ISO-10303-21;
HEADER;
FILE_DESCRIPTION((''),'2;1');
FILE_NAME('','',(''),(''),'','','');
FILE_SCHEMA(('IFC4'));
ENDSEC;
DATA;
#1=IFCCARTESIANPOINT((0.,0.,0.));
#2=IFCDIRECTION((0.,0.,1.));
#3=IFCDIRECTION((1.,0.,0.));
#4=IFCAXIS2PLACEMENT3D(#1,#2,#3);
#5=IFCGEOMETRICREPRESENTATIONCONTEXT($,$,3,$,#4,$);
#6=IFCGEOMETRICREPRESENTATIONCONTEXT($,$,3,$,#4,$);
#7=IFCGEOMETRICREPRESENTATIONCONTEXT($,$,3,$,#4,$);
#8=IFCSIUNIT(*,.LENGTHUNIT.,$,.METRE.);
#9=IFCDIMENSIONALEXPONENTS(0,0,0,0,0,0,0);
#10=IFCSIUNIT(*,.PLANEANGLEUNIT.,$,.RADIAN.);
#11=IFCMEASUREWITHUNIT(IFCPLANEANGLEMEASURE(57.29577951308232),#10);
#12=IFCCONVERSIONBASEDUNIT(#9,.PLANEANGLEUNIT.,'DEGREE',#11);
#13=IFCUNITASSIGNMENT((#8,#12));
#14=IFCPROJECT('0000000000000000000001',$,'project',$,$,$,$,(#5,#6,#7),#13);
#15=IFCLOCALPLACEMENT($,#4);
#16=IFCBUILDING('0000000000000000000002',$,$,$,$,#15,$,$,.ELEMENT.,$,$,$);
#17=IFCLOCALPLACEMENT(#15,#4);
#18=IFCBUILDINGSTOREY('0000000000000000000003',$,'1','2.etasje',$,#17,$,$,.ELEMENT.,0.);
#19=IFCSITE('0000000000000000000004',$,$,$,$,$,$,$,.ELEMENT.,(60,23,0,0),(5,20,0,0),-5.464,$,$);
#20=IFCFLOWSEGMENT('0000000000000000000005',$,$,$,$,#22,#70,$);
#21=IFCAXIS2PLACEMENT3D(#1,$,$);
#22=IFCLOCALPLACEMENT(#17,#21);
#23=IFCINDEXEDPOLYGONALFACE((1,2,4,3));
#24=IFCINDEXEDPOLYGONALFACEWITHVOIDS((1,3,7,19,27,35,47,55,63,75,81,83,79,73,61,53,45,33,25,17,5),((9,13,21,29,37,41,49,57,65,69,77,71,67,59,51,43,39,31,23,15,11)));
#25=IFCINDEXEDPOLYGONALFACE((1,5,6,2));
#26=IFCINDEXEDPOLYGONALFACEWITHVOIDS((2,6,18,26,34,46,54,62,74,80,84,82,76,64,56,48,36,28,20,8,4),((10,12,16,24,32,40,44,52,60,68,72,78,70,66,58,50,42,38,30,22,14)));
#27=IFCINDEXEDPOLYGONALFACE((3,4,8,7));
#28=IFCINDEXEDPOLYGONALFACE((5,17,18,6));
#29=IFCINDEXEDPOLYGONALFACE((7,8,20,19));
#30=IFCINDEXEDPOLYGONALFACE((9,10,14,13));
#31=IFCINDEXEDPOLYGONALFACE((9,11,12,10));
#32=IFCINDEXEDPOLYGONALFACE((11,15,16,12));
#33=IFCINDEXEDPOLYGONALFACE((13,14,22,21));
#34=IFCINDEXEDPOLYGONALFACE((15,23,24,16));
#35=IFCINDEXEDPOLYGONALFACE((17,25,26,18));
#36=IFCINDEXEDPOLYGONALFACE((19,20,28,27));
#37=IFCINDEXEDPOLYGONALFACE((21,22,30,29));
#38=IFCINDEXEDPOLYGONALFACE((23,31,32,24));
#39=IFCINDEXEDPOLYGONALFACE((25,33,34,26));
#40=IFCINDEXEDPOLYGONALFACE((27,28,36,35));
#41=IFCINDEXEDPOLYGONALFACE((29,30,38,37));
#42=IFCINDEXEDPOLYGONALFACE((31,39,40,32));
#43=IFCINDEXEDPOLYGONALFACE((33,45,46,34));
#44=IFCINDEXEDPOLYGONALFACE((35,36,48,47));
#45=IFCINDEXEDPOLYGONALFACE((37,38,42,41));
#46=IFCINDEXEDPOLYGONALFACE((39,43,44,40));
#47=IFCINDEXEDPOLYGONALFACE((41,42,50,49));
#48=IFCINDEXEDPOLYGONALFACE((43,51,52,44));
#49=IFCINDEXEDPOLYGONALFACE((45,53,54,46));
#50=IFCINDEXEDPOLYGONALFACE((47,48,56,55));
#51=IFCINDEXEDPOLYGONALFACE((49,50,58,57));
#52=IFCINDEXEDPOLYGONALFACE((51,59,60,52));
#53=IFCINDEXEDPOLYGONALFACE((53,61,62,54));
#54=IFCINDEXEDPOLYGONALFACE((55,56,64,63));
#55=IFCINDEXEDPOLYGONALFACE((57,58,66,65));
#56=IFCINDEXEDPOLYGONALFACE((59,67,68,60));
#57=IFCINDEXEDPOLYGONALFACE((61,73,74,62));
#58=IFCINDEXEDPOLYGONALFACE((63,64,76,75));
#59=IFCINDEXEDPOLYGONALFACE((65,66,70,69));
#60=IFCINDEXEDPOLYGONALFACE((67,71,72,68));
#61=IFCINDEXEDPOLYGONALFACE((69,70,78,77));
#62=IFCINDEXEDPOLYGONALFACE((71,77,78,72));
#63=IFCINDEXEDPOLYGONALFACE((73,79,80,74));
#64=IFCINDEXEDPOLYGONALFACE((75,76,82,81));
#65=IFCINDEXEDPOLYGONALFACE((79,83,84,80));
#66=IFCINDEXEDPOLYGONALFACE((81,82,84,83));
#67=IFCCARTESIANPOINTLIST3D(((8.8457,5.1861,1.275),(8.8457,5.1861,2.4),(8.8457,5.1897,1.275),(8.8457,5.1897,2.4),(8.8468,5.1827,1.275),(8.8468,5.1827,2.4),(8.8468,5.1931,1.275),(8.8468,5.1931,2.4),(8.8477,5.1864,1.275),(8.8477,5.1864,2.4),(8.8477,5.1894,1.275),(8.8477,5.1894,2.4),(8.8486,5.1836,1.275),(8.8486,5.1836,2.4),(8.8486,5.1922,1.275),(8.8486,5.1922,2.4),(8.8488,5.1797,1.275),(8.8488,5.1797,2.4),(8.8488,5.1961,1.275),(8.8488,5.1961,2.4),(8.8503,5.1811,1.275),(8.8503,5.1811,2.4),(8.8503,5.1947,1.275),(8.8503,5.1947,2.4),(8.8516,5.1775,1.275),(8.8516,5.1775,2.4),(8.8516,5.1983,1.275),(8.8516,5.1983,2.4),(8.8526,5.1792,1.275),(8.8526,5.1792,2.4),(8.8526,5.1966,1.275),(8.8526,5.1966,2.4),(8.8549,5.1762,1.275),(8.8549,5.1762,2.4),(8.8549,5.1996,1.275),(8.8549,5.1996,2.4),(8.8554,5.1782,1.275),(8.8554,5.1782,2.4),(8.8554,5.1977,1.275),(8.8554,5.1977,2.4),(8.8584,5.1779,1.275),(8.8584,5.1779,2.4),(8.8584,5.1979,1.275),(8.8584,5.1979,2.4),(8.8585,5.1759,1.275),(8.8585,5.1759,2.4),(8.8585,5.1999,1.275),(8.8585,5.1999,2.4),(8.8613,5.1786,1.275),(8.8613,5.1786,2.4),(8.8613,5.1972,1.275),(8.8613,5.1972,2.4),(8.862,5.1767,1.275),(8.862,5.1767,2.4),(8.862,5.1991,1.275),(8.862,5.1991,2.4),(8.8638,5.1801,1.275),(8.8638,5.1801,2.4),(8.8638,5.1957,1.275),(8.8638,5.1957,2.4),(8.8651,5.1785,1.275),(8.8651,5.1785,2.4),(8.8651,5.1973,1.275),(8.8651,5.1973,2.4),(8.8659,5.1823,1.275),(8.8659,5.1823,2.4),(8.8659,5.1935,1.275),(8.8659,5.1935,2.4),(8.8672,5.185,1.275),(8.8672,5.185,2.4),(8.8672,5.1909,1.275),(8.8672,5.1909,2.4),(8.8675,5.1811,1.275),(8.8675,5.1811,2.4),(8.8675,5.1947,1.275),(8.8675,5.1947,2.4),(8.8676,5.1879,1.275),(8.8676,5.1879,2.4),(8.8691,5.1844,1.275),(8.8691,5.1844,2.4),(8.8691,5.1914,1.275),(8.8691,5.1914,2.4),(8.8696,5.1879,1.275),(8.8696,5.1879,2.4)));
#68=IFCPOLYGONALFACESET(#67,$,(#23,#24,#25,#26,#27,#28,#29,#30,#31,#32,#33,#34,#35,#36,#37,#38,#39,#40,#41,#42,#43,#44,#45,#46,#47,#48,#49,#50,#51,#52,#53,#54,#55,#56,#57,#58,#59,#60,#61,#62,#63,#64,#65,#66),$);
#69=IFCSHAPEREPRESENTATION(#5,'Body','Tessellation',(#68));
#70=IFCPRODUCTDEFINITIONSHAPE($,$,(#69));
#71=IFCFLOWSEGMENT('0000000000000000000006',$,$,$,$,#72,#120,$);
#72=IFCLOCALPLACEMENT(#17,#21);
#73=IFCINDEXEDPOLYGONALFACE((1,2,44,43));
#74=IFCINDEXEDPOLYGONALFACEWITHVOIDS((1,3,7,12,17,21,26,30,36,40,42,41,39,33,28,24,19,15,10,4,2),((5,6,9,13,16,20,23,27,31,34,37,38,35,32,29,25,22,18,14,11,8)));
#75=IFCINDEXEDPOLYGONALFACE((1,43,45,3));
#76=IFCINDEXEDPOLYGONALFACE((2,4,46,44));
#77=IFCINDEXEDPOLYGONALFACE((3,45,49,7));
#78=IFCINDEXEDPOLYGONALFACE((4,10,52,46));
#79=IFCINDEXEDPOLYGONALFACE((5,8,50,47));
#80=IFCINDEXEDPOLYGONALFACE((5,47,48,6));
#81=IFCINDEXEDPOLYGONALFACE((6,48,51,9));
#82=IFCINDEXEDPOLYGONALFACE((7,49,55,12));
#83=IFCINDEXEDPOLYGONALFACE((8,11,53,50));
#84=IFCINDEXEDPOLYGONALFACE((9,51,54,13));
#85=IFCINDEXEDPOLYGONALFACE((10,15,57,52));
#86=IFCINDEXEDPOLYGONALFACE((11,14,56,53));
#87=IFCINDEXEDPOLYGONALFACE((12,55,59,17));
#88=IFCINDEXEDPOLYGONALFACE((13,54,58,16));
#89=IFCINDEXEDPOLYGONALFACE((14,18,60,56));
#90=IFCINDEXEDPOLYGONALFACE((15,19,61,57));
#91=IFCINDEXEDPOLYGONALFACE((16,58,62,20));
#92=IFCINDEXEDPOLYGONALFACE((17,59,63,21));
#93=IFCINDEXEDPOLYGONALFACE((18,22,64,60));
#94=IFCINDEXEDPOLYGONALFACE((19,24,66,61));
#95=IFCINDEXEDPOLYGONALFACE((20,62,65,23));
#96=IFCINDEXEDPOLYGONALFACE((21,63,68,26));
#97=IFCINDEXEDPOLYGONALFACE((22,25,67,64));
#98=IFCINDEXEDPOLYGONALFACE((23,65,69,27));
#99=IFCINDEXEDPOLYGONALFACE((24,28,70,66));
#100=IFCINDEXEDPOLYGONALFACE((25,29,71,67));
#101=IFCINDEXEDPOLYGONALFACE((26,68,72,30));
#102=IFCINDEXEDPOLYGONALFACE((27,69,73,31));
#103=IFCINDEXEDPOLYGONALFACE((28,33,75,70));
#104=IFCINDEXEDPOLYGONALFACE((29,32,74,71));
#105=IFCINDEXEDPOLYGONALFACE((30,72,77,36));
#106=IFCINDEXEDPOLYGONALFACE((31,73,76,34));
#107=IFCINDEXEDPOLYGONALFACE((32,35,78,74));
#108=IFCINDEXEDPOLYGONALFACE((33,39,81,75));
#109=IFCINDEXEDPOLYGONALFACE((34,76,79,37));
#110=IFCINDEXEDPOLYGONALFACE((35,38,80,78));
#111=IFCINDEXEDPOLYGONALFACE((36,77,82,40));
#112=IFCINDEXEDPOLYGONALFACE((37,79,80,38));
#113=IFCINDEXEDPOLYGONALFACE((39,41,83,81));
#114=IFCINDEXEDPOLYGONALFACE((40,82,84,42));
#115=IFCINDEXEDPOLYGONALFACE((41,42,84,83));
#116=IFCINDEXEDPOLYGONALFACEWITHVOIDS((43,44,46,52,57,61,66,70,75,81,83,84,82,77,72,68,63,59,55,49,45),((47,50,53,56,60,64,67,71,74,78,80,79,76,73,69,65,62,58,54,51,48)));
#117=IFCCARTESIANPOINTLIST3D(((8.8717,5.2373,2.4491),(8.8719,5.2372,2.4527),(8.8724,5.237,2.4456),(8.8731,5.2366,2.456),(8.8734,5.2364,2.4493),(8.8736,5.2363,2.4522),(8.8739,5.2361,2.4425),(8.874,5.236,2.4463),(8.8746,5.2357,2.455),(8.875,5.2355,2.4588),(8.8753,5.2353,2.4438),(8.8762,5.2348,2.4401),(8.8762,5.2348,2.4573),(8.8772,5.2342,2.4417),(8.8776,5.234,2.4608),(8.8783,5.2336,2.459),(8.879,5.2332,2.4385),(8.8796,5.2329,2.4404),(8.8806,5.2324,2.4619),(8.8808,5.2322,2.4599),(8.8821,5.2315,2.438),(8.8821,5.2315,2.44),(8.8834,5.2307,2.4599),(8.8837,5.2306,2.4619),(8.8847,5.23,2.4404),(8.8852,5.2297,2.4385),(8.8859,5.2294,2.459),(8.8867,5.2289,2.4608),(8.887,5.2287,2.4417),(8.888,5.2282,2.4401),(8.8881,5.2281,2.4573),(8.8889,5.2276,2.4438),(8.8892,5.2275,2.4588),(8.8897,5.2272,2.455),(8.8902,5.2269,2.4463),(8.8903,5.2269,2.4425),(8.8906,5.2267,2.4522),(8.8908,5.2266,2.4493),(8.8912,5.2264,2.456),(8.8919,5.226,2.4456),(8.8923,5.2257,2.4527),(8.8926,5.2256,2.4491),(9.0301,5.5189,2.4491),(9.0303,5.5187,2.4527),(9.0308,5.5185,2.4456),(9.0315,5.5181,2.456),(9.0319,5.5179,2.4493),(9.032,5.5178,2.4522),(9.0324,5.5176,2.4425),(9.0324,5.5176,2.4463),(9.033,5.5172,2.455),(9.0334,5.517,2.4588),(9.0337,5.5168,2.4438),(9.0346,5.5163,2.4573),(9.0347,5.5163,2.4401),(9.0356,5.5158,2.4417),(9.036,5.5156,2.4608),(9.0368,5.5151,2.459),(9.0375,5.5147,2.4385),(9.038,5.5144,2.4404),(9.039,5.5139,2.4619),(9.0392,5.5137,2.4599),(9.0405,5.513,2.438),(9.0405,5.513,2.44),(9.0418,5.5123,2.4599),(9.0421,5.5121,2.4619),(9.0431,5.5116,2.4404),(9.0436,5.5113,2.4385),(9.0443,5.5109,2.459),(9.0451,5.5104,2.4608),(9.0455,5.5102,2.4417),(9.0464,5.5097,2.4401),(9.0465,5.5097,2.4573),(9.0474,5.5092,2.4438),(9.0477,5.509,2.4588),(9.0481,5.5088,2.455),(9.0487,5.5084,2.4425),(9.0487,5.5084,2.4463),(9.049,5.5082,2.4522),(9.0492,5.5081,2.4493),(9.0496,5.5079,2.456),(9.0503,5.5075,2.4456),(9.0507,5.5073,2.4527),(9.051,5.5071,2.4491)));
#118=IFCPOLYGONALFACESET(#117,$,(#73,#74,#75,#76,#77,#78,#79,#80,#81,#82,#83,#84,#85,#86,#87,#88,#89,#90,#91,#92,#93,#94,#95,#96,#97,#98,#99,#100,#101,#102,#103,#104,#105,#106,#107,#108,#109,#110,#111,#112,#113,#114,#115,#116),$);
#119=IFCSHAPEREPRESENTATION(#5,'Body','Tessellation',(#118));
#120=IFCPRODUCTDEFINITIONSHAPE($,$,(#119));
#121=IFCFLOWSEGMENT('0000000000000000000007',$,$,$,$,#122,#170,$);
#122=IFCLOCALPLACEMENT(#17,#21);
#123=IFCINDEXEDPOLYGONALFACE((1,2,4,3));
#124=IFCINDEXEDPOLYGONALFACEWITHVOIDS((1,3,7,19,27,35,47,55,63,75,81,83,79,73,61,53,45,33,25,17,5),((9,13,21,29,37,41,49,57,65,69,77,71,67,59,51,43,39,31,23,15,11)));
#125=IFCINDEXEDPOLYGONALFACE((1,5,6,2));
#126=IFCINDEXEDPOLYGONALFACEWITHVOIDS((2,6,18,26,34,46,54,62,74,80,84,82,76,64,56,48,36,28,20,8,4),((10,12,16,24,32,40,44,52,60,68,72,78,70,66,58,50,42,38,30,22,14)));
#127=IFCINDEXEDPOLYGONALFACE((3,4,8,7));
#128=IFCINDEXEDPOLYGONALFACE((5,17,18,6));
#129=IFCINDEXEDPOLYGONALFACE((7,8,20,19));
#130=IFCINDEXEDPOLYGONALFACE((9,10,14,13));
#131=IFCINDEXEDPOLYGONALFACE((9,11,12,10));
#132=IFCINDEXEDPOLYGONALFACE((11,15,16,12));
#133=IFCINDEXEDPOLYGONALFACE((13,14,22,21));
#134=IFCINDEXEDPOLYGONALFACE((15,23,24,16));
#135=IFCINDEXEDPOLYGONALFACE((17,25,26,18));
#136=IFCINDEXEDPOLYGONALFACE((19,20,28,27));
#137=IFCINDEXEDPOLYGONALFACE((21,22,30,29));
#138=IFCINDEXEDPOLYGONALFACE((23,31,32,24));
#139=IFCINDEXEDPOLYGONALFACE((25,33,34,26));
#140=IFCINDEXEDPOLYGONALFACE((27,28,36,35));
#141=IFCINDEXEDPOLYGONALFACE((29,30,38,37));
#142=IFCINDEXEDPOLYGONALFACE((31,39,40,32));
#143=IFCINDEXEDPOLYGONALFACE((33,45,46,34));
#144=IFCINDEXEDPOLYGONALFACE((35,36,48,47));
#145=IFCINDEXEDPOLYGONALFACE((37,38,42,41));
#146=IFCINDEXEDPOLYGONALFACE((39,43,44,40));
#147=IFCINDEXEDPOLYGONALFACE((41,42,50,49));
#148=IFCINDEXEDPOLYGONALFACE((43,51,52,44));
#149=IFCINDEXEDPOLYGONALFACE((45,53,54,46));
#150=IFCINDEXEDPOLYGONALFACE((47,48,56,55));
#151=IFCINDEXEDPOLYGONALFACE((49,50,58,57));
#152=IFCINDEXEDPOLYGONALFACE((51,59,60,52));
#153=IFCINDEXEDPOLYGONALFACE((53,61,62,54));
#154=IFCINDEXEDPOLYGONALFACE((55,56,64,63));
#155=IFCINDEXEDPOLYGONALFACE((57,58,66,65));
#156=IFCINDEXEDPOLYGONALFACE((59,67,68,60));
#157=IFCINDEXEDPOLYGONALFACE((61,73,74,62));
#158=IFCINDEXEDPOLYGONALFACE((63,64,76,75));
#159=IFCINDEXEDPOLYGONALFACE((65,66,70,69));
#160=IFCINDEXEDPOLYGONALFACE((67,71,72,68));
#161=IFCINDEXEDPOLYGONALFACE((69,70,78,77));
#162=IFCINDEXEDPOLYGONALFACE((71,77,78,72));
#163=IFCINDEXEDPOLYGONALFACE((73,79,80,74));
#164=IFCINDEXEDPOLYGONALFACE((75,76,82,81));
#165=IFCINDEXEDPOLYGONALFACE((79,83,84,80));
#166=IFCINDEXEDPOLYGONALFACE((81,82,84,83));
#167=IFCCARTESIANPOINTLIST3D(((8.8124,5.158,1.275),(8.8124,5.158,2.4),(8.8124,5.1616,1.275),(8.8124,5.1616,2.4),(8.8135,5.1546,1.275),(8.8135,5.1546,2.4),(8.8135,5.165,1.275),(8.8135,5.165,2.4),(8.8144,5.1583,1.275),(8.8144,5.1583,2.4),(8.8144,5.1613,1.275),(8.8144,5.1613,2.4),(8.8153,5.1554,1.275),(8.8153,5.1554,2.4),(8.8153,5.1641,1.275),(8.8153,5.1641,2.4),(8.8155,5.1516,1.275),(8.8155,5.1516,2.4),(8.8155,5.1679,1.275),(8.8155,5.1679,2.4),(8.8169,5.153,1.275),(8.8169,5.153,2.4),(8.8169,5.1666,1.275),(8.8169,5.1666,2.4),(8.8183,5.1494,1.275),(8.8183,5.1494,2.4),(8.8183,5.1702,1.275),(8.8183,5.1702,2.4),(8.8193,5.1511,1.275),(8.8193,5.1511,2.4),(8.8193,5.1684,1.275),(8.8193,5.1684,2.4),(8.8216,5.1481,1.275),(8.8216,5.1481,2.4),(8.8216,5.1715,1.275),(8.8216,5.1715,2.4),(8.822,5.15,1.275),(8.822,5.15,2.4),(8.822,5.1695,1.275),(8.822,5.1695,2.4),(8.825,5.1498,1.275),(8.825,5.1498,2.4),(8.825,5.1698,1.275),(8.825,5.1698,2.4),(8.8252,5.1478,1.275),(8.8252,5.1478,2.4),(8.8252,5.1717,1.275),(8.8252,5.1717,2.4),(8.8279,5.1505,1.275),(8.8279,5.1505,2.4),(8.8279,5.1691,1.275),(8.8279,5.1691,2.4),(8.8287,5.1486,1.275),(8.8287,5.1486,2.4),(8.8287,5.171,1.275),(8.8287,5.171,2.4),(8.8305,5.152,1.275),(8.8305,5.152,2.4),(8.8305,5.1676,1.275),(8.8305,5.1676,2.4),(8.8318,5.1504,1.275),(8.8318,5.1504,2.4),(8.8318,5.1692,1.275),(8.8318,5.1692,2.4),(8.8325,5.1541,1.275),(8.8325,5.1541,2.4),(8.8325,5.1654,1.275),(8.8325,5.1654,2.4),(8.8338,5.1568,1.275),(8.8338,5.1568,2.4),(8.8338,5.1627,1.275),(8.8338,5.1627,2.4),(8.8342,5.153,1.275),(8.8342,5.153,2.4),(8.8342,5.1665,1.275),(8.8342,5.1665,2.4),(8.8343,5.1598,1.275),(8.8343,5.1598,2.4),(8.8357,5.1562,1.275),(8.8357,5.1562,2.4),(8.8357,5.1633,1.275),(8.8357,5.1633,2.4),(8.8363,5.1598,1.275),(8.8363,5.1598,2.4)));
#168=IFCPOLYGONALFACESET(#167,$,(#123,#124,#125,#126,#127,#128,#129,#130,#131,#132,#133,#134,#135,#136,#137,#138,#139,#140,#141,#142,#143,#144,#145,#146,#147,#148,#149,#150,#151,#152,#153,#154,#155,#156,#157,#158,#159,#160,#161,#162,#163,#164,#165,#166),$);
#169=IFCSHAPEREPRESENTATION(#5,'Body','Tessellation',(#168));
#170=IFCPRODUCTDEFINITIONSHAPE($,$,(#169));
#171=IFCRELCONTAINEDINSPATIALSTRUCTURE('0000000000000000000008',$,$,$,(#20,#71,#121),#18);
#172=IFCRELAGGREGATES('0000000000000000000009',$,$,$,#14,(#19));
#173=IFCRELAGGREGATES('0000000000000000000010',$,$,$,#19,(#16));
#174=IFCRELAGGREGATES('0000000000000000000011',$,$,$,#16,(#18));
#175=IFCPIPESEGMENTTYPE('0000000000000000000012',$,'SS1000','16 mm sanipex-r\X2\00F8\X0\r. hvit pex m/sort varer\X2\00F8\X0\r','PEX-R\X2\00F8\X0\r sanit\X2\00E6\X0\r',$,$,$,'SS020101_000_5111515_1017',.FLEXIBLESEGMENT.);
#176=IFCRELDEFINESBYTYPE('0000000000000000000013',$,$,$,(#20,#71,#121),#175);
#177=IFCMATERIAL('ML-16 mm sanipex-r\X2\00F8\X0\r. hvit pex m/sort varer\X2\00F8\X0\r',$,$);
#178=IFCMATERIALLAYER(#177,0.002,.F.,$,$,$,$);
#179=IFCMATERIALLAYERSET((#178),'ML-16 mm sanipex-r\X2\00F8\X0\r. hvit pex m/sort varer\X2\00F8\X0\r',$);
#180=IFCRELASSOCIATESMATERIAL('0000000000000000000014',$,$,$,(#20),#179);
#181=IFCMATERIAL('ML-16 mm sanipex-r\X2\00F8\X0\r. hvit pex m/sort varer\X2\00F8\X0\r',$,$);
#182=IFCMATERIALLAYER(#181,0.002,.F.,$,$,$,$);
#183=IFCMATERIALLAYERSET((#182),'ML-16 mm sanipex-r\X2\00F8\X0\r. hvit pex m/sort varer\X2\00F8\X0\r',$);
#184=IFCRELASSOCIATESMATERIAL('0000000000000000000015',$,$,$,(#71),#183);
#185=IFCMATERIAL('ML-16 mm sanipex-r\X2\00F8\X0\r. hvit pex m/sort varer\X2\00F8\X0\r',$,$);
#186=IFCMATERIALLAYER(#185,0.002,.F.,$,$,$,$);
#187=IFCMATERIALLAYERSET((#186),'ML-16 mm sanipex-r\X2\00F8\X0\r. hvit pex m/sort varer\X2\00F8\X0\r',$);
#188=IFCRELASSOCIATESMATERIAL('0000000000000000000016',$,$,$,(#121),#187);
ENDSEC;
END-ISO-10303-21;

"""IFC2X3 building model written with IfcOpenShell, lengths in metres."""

from ifc_helpers import new_model, entity, si_unit, converted_unit, frame, origin_with_axes, origin_2d_with_axis, place, context, project, spatial, hollow_circle, extrude, material, layer, layer_set, layer_usage, type_object, element, save


model = new_model("IFC2X3")

# Units and contexts
context_of_model_1 = context(None, 3, world=origin_with_axes())
context_of_model_2 = context(None, 3, world=origin_with_axes())
context_of_model_3 = context(None, 3, world=origin_with_axes())
ifc_project = project(units=[si_unit("LENGTHUNIT", "METRE"), converted_unit("PLANEANGLEUNIT", "DEGREE", entity("IfcPlaneAngleMeasure", 57.29577951308232), si_unit("PLANEANGLEUNIT", "RADIAN"), dimensions=[0, 0, 0, 0, 0, 0, 0])], contexts=[context_of_model_1, context_of_model_2, context_of_model_3])

# Site, building, storey
site = spatial("IfcSite", under=ifc_project, CompositionType="ELEMENT", RefLatitude=(60, 23, 0, 0), RefLongitude=(5, 20, 0, 0), RefElevation=-5.464)
building_placement = place(None, origin_with_axes())
building = spatial("IfcBuilding", under=site, at=building_placement, CompositionType="ELEMENT")
storey_placement = place(building_placement, origin_with_axes())
storey = spatial("IfcBuildingStorey", under=building, at=storey_placement, Name="1", Description="2.etasje", CompositionType="ELEMENT", Elevation=0.0)

# Flow segments
pipe_segment_type_1 = type_object("IfcPipeSegmentType", Name="SS1000", Description="16 mm sanipex-rør. hvit pex m/sort varerør", ApplicableOccurrence="PEX-Rør sanitær", ElementType="SS020101_000_5111515_1017", PredefinedType="FLEXIBLESEGMENT")
ifc_material_1 = material(Name="ML-16 mm sanipex-rør. hvit pex m/sort varerør")
ifc_layer_1 = layer(ifc_material_1, 0.002, ventilated=False)
ifc_layer_set_1 = layer_set([ifc_layer_1], Name="ML-16 mm sanipex-rør. hvit pex m/sort varerør")
ifc_layer_usage_1 = layer_usage(ifc_layer_set_1, "AXIS2", "POSITIVE", 0.0)
flow_segment_1_placement = place(storey_placement, frame((8.8576, 5.1879, 1.275), z_axis=(0.0, 0.0, 1.0), x_axis=(1.0, 0.0, 0.0)))
element("IfcFlowSegment", 1, at=flow_segment_1_placement, inside=storey, type_object=pipe_segment_type_1, material=ifc_layer_usage_1, context=context_of_model_1, shape_type="SweptSolid", body=[
    extrude(hollow_circle(Radius=0.012, WallThickness=0.002, at=origin_2d_with_axis()), origin_with_axes(), (0.0, 0.0, 1.0), 1.125),
])
ifc_material_2 = material(Name="ML-16 mm sanipex-rør. hvit pex m/sort varerør")
ifc_layer_2 = layer(ifc_material_2, 0.002, ventilated=False)
ifc_layer_set_2 = layer_set([ifc_layer_2], Name="ML-16 mm sanipex-rør. hvit pex m/sort varerør")
ifc_layer_usage_2 = layer_usage(ifc_layer_set_2, "AXIS2", "POSITIVE", 0.0)
flow_segment_2_placement = place(storey_placement, frame((8.8821, 5.2315, 2.45), z_axis=(0.490408, 0.871493, 0.0), x_axis=(0.0, 0.0, -1.0)))
element("IfcFlowSegment", 2, at=flow_segment_2_placement, inside=storey, type_object=pipe_segment_type_1, material=ifc_layer_usage_2, context=context_of_model_1, shape_type="SweptSolid", body=[
    extrude(hollow_circle(Radius=0.012, WallThickness=0.002, at=origin_2d_with_axis()), origin_with_axes(), (0.0, 0.0, 1.0), 0.323),
])
ifc_material_3 = material(Name="ML-16 mm sanipex-rør. hvit pex m/sort varerør")
ifc_layer_3 = layer(ifc_material_3, 0.002, ventilated=False)
ifc_layer_set_3 = layer_set([ifc_layer_3], Name="ML-16 mm sanipex-rør. hvit pex m/sort varerør")
ifc_layer_usage_3 = layer_usage(ifc_layer_set_3, "AXIS2", "POSITIVE", 0.0)
flow_segment_3_placement = place(storey_placement, frame((8.8243, 5.1598, 1.275), z_axis=(0.0, 0.0, 1.0), x_axis=(1.0, 0.0, 0.0)))
element("IfcFlowSegment", 3, at=flow_segment_3_placement, inside=storey, type_object=pipe_segment_type_1, material=ifc_layer_usage_3, context=context_of_model_1, shape_type="SweptSolid", body=[
    extrude(hollow_circle(Radius=0.012, WallThickness=0.002, at=origin_2d_with_axis()), origin_with_axes(), (0.0, 0.0, 1.0), 1.125),
])

save(model, "model.ifc")
